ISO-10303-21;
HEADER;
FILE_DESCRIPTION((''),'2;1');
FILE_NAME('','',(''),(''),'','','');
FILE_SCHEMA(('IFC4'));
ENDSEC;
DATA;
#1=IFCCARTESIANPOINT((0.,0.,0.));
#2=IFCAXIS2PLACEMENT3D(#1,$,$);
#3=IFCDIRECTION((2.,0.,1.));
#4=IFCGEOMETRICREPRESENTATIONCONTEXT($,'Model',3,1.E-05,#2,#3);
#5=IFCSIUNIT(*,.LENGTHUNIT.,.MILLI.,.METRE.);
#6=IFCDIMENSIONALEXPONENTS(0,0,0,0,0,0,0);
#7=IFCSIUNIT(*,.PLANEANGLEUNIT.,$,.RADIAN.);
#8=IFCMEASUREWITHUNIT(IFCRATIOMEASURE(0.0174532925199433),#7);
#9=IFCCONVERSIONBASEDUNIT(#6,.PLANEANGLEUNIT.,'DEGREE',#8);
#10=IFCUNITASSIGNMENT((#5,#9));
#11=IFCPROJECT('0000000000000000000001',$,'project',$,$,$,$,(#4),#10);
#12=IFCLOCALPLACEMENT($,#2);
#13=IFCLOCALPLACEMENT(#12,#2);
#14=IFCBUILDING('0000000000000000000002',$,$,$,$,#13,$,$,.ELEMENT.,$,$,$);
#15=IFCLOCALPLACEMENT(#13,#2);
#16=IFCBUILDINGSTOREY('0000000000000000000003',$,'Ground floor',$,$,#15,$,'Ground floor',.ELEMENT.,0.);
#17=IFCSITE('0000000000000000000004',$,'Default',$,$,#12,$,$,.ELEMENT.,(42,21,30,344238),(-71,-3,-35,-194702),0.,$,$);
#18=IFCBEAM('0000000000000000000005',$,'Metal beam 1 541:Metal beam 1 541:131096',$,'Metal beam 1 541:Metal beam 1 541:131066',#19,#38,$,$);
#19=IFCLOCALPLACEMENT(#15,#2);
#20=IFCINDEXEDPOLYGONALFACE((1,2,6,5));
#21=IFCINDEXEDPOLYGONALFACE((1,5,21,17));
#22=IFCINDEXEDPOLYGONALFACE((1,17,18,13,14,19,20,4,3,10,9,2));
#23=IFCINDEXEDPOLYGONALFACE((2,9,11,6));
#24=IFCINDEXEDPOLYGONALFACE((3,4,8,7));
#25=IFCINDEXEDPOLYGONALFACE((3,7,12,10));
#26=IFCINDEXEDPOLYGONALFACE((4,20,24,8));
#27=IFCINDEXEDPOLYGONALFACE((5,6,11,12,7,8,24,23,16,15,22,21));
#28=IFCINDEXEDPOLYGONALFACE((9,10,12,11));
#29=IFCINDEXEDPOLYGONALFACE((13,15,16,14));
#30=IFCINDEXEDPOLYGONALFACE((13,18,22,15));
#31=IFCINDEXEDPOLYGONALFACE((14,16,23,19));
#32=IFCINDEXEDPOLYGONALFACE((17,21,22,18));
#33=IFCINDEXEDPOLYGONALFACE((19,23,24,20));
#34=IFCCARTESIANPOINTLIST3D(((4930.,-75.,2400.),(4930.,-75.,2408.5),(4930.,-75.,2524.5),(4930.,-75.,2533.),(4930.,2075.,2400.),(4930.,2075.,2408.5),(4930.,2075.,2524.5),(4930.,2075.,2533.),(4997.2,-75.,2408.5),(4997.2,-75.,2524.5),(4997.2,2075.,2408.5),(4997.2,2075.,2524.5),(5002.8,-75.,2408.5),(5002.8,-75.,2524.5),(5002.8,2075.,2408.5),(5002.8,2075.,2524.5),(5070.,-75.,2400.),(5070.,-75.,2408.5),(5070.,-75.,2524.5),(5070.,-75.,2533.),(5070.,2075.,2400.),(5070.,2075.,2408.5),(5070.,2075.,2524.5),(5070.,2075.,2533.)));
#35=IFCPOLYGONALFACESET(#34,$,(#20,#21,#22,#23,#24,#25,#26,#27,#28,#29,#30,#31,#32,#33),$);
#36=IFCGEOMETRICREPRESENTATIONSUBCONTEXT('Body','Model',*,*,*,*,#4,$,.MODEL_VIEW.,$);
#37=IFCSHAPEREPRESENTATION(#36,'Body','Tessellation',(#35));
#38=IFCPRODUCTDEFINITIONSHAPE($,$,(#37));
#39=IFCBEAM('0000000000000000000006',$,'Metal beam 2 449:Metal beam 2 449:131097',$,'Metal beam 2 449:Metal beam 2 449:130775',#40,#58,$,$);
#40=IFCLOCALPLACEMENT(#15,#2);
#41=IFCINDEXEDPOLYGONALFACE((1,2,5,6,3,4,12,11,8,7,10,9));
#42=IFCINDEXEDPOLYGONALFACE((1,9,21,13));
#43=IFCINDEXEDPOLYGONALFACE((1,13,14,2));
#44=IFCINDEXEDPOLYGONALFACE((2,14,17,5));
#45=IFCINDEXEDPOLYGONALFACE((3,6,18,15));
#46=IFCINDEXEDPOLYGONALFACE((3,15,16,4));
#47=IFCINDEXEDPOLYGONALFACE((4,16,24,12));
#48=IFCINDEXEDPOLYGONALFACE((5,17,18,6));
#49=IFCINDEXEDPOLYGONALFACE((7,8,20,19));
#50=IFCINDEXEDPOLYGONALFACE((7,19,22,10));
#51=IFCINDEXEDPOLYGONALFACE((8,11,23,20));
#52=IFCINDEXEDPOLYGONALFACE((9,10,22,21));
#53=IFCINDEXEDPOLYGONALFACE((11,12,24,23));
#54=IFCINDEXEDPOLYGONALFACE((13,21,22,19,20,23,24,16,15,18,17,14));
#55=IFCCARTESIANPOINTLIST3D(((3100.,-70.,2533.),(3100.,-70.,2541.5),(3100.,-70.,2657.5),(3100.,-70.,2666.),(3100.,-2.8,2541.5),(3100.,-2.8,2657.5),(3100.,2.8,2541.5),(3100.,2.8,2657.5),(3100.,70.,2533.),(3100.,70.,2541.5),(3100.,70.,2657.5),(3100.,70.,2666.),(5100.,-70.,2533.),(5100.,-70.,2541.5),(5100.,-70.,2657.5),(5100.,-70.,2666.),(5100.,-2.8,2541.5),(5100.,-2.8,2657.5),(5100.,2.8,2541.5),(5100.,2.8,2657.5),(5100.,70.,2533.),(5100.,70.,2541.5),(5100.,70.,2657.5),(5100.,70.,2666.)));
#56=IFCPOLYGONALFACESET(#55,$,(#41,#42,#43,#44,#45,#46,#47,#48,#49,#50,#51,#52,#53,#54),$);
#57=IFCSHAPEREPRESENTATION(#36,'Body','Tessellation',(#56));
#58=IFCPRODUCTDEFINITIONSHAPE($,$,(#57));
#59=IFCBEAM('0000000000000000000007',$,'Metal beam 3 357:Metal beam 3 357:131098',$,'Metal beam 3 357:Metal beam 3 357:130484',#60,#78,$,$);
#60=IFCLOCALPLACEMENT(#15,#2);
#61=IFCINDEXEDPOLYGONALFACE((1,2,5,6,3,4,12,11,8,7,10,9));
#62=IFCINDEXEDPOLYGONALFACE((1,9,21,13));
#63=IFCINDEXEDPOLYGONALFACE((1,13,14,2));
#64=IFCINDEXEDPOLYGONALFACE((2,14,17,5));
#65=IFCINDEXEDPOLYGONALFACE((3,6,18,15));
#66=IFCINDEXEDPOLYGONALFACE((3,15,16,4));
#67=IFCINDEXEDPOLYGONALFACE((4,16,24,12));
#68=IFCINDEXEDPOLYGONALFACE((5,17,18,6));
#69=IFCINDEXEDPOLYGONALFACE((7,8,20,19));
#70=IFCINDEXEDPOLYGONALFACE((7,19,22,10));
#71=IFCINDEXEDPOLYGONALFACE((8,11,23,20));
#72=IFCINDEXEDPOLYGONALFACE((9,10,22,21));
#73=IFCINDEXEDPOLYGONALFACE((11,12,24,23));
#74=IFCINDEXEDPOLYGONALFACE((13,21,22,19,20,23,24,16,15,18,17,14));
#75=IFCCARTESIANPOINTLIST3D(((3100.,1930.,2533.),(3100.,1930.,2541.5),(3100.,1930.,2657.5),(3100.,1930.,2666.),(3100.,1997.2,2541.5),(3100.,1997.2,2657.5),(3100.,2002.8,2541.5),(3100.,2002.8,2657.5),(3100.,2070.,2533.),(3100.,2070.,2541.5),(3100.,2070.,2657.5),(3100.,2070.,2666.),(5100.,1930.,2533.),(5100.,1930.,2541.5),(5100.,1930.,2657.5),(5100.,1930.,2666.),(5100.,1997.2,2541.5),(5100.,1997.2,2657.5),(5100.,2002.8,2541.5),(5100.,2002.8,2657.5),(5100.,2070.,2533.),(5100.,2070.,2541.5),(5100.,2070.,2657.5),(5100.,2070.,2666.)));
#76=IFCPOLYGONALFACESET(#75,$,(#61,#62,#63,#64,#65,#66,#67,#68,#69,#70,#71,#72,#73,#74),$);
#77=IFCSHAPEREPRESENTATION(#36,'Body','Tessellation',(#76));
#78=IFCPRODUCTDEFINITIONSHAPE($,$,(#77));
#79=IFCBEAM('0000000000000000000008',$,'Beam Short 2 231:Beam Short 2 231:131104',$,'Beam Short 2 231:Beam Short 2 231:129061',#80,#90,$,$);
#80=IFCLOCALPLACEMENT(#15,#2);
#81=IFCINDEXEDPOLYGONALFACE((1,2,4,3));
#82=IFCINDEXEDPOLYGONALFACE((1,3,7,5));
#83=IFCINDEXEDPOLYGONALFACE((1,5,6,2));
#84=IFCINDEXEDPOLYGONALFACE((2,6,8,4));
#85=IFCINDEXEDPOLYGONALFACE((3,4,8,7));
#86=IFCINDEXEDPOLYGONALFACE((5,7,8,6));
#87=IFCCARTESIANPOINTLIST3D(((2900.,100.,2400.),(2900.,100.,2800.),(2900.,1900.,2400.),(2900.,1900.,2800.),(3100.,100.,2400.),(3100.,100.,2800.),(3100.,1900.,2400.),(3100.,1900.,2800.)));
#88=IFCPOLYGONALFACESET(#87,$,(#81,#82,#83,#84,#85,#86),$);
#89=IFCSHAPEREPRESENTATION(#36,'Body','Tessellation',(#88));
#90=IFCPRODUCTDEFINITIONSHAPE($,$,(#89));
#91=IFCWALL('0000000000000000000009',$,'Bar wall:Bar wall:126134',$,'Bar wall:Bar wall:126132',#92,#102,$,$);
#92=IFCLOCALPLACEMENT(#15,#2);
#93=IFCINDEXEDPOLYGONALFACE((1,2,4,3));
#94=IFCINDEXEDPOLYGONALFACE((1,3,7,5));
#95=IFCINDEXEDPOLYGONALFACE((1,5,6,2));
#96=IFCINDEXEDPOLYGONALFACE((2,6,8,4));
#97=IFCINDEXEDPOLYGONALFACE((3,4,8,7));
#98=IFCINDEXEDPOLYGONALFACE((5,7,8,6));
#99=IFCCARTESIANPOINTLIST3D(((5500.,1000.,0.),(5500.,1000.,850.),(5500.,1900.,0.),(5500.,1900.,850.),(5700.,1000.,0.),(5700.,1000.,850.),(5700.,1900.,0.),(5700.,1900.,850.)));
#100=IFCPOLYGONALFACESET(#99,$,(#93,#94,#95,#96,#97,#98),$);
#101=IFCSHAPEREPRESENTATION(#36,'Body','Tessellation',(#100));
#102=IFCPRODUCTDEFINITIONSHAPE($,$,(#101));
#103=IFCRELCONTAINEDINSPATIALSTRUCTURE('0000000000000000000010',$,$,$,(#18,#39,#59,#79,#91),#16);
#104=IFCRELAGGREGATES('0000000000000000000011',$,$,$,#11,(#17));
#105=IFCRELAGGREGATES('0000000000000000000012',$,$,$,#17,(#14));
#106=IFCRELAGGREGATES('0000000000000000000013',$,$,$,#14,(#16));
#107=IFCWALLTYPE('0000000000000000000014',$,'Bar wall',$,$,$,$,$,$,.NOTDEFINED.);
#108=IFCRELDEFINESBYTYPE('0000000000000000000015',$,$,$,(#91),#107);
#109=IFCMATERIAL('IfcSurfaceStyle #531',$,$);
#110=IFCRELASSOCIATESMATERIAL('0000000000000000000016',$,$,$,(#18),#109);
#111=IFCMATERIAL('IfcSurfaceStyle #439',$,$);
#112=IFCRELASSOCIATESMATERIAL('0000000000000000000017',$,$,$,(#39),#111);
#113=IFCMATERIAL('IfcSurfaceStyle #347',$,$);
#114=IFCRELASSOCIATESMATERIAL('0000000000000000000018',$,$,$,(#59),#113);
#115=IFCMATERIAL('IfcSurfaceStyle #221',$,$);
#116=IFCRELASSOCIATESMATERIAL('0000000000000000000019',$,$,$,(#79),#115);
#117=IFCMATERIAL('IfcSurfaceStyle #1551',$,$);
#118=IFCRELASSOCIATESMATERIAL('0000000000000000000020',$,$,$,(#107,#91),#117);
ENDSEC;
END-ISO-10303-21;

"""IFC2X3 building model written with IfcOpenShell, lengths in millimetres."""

from ifc_helpers import new_model, entity, si_unit, converted_unit, direction, frame, frame_2d, origin, origin_2d_with_axis, place, context, subcontext, project, spatial, rectangle, i_section, extrude, material, type_object, element, save


model = new_model("IFC2X3")

# Units and contexts
model_context = context("Model", 3, precision=1e-05, world=origin(), true_north=direction((2.0, 0.0, 1.0)))
body_context = subcontext(model_context, "Body", "Model", "MODEL_VIEW")
ifc_project = project(units=[si_unit("LENGTHUNIT", "METRE", prefix="MILLI"), converted_unit("PLANEANGLEUNIT", "DEGREE", entity("IfcRatioMeasure", 0.0174532925199433), si_unit("PLANEANGLEUNIT", "RADIAN"), dimensions=[0, 0, 0, 0, 0, 0, 0])], contexts=[model_context])

# Site, building, storey
site_placement = place(None, origin())
site = spatial("IfcSite", under=ifc_project, at=site_placement, Name="Default", CompositionType="ELEMENT", RefLatitude=(42, 21, 30, 344238), RefLongitude=(-71, -3, -35, -194702), RefElevation=0.0)
building_placement = place(site_placement, origin())
building = spatial("IfcBuilding", under=site, at=building_placement, CompositionType="ELEMENT")
storey_placement = place(building_placement, origin())
storey = spatial("IfcBuildingStorey", under=building, at=storey_placement, Name="Ground floor", LongName="Ground floor", CompositionType="ELEMENT", Elevation=0.0)

# Beams
ifc_material_1 = material(Name="IfcSurfaceStyle #531")
beam_1_placement = place(storey_placement, frame((4930.0, -75.0, 2400.0)))
element("IfcBeam", 1, at=beam_1_placement, inside=storey, material=ifc_material_1, Name="Metal beam 1 541:Metal beam 1 541:131096", ObjectType="Metal beam 1 541:Metal beam 1 541:131066", context=body_context, shape_type="SweptSolid", body=[
    extrude(i_section(OverallWidth=140.0, OverallDepth=133.0, WebThickness=5.5, FlangeThickness=8.5, at=frame_2d((0.0, 0.0), x_axis=(1.0, 0.0))), frame((70.0, 0.0, 66.5), z_axis=(0.0, 1.0, 0.0), x_axis=(-1.0, 0.0, 0.0)), (0.0, 0.0, 1.0), 2150.0),
])
ifc_material_2 = material(Name="IfcSurfaceStyle #439")
beam_2_placement = place(storey_placement, frame((3100.0, -70.0, 2533.0)))
element("IfcBeam", 2, at=beam_2_placement, inside=storey, material=ifc_material_2, Name="Metal beam 2 449:Metal beam 2 449:131097", ObjectType="Metal beam 2 449:Metal beam 2 449:130775", context=body_context, shape_type="SweptSolid", body=[
    extrude(i_section(OverallWidth=140.0, OverallDepth=133.0, WebThickness=5.5, FlangeThickness=8.5, at=frame_2d((0.0, 0.0), x_axis=(1.0, 0.0))), frame((0.0, 70.0, 66.5), z_axis=(1.0, 0.0, 0.0), x_axis=(0.0, 1.0, 0.0)), (0.0, 0.0, 1.0), 2000.0),
])
ifc_material_3 = material(Name="IfcSurfaceStyle #347")
beam_3_placement = place(storey_placement, frame((3100.0, 1930.0, 2533.0)))
element("IfcBeam", 3, at=beam_3_placement, inside=storey, material=ifc_material_3, Name="Metal beam 3 357:Metal beam 3 357:131098", ObjectType="Metal beam 3 357:Metal beam 3 357:130484", context=body_context, shape_type="SweptSolid", body=[
    extrude(i_section(OverallWidth=140.0, OverallDepth=133.0, WebThickness=5.5, FlangeThickness=8.5, at=frame_2d((0.0, 0.0), x_axis=(1.0, 0.0))), frame((0.0, 70.0, 66.5), z_axis=(1.0, 0.0, 0.0), x_axis=(0.0, 1.0, 0.0)), (0.0, 0.0, 1.0), 2000.0),
])
ifc_material_4 = material(Name="IfcSurfaceStyle #221")
beam_4_placement = place(storey_placement, frame((2900.0, 100.0, 2400.0)))
element("IfcBeam", 4, at=beam_4_placement, inside=storey, material=ifc_material_4, Name="Beam Short 2 231:Beam Short 2 231:131104", ObjectType="Beam Short 2 231:Beam Short 2 231:129061", context=body_context, shape_type="SweptSolid", body=[
    extrude(rectangle(XDim=400.0, YDim=1800.0, at=frame_2d((0.0, 0.0), x_axis=(0.0, 1.0))), frame((0.0, 900.0, 200.0), z_axis=(1.0, 0.0, 0.0), x_axis=(0.0, -1.0, 0.0)), (0.0, 0.0, 1.0), 200.0),
])

# Wall
ifc_material_5 = material(Name="IfcSurfaceStyle #1551")
wall_type = type_object("IfcWallType", Name="Bar wall", PredefinedType="NOTDEFINED", material=ifc_material_5)
wall_placement = place(building_placement, frame((5500.0, 1000.0, 0.0), z_axis=(0.0, 0.0, 1.0), x_axis=(0.0, 1.0, 0.0)))
element("IfcWall", 5, at=wall_placement, inside=storey, type_object=wall_type, material=ifc_material_5, Name="Bar wall:Bar wall:126134", ObjectType="Bar wall:Bar wall:126132", context=body_context, shape_type="SweptSolid", body=[
    extrude(rectangle(XDim=200.0, YDim=900.0, at=origin_2d_with_axis()), frame((450.0, -100.0, 0.0), z_axis=(0.0, 0.0, 1.0), x_axis=(0.0, -1.0, 0.0)), (0.0, 0.0, 1.0), 850.0),
])

save(model, "model.ifc")
